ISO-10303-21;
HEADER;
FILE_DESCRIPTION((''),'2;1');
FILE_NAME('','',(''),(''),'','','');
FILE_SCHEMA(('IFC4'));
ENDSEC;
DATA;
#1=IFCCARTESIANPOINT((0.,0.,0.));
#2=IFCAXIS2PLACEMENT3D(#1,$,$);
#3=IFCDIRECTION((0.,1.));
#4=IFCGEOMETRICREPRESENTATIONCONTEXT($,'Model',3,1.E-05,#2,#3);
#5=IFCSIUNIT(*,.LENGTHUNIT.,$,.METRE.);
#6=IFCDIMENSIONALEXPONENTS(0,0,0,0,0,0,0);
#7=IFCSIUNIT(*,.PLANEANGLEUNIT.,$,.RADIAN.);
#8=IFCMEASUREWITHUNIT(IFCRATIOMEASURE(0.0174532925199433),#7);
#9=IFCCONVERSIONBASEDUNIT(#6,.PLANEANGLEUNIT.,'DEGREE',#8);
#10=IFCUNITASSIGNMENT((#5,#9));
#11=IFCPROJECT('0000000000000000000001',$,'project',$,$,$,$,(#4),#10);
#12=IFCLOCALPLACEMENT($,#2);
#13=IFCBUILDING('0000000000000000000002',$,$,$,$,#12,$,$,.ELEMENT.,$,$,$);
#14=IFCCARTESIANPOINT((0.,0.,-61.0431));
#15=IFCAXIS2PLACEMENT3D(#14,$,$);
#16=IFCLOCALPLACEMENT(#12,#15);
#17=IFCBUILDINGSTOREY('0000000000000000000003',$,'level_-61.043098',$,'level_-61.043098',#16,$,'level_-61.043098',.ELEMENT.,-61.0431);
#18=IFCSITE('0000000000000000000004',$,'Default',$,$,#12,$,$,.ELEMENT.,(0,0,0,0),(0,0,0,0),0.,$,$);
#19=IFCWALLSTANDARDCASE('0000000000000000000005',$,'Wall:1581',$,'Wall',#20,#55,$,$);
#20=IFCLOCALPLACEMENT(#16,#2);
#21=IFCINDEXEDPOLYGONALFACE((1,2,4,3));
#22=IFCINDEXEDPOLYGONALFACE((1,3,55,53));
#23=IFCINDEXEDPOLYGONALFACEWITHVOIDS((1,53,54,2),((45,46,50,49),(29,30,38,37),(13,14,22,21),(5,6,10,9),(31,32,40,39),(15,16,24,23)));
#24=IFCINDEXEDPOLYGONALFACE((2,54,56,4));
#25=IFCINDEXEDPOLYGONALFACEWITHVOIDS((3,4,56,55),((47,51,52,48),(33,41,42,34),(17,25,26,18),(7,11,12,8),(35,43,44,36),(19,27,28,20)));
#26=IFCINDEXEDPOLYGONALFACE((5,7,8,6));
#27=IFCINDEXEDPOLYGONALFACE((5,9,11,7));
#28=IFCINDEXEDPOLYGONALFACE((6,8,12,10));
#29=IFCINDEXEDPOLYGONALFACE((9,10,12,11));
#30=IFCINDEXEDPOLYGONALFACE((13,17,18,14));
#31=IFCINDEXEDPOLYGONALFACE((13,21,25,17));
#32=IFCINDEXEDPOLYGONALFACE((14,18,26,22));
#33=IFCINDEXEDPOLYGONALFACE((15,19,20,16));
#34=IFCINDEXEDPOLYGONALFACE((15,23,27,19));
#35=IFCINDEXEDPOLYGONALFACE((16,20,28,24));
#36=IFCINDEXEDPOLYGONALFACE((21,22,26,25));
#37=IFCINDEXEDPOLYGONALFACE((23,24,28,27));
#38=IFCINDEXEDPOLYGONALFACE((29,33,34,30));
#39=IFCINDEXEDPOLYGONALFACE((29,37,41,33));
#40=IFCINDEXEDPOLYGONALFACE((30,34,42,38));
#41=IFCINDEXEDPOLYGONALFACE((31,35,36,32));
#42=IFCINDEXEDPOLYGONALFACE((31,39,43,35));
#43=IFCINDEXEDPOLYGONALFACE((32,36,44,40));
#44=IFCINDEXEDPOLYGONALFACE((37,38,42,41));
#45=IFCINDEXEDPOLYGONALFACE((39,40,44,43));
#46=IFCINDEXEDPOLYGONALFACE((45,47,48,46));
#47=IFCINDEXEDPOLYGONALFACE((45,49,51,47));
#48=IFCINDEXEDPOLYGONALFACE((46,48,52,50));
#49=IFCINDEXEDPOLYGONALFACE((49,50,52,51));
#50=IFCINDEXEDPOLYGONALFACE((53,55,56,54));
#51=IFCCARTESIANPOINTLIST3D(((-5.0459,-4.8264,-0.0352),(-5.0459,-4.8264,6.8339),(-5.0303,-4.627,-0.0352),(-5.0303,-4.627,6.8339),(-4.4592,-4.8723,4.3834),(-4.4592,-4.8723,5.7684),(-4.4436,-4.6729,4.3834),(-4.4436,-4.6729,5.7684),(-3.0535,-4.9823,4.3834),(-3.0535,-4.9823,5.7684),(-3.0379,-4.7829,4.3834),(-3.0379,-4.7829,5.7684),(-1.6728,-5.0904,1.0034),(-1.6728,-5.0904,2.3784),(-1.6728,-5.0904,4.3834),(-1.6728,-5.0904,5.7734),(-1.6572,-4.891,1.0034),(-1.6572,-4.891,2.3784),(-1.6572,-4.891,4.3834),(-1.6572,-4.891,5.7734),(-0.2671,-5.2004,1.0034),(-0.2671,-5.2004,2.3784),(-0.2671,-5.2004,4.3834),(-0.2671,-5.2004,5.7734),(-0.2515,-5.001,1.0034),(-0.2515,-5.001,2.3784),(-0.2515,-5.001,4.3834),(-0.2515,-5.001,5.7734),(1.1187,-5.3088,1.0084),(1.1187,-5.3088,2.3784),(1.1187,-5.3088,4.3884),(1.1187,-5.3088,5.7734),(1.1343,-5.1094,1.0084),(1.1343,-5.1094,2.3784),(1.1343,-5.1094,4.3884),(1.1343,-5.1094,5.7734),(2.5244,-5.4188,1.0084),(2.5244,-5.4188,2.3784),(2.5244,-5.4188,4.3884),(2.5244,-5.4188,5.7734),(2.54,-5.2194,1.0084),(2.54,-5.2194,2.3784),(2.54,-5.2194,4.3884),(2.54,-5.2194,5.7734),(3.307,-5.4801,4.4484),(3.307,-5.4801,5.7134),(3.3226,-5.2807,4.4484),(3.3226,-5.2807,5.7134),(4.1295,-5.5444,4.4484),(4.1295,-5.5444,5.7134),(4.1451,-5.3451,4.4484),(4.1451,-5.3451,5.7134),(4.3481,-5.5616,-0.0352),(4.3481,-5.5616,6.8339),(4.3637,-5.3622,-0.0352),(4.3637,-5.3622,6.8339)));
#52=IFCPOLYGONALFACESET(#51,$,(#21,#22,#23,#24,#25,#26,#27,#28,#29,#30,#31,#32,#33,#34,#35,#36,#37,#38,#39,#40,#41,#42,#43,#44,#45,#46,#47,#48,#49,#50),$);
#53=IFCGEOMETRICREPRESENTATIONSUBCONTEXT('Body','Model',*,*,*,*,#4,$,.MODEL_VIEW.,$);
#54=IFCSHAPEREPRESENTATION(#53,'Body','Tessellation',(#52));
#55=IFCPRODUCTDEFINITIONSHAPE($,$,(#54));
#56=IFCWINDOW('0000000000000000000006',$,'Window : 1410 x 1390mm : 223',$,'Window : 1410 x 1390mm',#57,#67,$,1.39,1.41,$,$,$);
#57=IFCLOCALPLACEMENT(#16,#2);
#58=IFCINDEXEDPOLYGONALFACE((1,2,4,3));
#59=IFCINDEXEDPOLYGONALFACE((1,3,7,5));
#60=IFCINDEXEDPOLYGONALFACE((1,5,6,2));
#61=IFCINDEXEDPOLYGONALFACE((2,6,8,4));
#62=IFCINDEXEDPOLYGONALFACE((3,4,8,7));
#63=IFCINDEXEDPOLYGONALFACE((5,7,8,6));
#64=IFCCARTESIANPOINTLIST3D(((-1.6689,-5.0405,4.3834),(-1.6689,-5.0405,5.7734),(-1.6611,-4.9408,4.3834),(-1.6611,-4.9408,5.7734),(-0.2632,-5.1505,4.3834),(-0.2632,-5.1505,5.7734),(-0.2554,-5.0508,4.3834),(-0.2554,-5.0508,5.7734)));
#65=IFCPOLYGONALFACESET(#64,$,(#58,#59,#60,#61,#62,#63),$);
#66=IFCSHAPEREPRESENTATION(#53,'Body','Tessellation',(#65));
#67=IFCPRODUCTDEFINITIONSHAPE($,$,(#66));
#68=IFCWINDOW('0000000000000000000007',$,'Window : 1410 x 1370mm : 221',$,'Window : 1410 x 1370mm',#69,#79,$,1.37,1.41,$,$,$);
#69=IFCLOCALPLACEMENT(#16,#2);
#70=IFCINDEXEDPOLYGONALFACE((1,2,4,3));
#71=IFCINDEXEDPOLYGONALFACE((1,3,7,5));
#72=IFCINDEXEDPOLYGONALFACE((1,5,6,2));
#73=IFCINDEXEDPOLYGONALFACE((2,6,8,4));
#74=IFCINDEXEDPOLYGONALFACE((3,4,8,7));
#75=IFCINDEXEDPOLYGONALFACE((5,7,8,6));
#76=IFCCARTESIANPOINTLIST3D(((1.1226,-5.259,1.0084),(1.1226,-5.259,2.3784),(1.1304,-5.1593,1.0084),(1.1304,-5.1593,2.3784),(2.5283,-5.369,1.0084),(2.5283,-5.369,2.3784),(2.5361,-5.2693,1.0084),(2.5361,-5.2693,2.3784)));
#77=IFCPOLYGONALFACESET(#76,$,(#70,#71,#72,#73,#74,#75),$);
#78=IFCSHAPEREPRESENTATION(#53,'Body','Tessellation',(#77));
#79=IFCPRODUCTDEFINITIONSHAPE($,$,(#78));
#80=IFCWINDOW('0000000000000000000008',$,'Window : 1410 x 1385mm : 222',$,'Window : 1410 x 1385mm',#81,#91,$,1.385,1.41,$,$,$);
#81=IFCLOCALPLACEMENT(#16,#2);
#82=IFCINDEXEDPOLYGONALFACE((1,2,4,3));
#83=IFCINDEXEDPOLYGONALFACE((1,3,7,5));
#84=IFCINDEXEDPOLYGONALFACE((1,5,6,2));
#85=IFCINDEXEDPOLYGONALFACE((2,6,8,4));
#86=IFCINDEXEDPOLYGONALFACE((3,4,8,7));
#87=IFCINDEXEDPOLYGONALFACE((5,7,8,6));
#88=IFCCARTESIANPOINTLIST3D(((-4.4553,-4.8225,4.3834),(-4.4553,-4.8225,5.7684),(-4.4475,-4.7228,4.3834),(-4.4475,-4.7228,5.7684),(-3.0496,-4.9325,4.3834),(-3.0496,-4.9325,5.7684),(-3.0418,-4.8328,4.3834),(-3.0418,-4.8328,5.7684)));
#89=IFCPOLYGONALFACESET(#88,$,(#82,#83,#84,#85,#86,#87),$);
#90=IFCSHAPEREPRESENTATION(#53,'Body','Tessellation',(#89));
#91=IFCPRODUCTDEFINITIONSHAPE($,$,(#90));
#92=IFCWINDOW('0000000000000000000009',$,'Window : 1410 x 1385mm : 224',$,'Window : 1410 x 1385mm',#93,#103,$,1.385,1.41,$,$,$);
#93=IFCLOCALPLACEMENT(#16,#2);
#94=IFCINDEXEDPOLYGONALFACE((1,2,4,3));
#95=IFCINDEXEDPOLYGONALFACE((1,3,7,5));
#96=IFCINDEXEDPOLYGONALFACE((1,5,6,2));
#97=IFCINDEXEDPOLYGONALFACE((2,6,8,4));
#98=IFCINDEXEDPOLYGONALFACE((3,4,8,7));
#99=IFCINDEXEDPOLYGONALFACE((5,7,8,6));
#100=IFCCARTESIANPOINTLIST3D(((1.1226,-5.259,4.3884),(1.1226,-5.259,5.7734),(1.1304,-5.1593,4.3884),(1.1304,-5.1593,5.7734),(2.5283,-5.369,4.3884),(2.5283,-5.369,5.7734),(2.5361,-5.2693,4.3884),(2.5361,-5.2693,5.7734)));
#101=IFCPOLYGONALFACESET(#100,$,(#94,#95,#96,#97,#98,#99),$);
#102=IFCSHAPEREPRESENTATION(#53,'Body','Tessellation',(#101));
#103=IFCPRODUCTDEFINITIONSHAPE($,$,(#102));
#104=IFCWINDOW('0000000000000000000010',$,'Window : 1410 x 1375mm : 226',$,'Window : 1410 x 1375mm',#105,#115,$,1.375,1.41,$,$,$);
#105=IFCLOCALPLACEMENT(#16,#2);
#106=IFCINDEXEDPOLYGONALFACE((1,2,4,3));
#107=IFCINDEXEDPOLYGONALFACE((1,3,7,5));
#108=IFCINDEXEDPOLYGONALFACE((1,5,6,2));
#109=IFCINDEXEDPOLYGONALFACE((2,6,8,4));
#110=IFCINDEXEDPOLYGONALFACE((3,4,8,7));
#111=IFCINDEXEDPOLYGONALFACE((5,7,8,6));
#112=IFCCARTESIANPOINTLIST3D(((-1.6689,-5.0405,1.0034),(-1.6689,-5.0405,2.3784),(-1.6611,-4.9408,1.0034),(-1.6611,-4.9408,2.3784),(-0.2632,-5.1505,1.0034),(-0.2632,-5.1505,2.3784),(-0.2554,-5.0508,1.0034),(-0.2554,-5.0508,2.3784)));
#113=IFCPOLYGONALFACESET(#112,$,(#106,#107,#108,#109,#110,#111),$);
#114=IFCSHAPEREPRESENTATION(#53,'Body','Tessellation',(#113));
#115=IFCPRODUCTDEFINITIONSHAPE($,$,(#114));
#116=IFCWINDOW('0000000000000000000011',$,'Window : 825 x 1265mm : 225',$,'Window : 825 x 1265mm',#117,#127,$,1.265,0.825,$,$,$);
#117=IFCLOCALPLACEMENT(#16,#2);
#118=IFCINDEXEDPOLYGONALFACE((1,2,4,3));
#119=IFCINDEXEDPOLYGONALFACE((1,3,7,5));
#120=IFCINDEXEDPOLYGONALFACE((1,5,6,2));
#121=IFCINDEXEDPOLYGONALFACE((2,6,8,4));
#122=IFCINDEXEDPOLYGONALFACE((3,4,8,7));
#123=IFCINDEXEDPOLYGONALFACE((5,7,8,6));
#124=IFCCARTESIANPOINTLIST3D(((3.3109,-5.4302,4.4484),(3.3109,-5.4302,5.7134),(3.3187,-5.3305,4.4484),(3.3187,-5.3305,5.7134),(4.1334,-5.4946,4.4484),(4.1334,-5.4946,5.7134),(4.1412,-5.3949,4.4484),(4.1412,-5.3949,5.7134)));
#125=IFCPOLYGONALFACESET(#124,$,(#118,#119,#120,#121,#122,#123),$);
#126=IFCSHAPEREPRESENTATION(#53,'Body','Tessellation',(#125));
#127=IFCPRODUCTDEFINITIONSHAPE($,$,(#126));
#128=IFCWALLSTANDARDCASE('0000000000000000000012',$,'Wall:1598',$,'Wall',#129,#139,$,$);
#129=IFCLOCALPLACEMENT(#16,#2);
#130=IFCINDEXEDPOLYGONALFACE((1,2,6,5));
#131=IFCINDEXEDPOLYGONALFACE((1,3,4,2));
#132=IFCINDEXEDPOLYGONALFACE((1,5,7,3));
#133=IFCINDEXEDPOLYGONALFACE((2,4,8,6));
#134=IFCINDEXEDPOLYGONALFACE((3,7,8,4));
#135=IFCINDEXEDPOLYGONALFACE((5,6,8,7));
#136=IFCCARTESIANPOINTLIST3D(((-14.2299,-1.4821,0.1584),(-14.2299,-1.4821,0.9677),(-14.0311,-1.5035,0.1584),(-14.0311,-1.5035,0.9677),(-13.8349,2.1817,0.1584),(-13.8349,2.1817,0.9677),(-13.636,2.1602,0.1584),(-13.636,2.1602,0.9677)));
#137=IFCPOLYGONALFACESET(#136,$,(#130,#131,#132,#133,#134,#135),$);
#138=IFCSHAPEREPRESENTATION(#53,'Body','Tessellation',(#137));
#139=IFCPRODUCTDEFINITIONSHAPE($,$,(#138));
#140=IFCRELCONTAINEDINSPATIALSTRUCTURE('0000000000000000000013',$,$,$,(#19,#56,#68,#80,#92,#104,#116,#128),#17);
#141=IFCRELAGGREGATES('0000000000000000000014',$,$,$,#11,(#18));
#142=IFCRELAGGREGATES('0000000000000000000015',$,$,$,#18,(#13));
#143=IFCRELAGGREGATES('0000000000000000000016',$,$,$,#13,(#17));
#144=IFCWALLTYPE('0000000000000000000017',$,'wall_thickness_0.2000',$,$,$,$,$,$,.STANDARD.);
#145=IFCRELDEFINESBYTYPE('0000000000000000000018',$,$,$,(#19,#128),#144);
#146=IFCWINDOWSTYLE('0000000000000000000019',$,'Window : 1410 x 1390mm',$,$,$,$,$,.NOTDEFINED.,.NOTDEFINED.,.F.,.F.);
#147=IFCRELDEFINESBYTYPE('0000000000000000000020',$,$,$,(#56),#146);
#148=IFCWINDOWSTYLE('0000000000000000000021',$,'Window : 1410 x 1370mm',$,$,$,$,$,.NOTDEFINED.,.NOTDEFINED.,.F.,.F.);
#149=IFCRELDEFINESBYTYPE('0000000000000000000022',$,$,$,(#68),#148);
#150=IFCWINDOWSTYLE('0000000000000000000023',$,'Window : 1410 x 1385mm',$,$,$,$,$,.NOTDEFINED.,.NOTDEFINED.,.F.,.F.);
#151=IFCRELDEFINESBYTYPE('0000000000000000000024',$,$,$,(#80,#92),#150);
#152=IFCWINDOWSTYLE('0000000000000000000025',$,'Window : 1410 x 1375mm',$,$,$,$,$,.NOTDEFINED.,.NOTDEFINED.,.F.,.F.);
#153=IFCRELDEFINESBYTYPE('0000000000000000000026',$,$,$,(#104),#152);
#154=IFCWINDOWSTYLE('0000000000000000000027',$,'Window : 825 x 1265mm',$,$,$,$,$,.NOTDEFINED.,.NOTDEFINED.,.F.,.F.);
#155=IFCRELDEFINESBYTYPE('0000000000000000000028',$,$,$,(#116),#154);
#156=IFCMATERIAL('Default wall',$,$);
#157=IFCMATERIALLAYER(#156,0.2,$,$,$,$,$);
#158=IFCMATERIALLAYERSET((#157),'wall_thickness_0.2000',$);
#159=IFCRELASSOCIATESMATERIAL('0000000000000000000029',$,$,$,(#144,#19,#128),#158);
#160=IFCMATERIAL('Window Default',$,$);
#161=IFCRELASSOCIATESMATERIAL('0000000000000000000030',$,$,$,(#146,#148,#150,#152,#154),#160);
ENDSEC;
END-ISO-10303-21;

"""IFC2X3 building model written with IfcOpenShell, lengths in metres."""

from ifc_helpers import new_model, entity, si_unit, converted_unit, direction, frame, frame_2d, origin, origin_2d_with_axis, place, context, subcontext, project, spatial, polyline, rectangle, outline, extrude, source, transform, mapped, material, layer, layer_set, layer_usage, type_object, type_shapes, element, fill, save


model = new_model("IFC2X3")

# Units and contexts
model_context = context("Model", 3, precision=1e-05, world=origin(), true_north=direction((0.0, 1.0)))
body_context = subcontext(model_context, "Body", "Model", "MODEL_VIEW")
ifc_project = project(units=[si_unit("LENGTHUNIT", "METRE"), converted_unit("PLANEANGLEUNIT", "DEGREE", entity("IfcRatioMeasure", 0.0174532925199433), si_unit("PLANEANGLEUNIT", "RADIAN"), dimensions=[0, 0, 0, 0, 0, 0, 0])], contexts=[model_context])

# Site, building, storey
placement_1 = place(None, origin())
site = spatial("IfcSite", under=ifc_project, at=placement_1, Name="Default", CompositionType="ELEMENT", RefLatitude=(0, 0, 0, 0), RefLongitude=(0, 0, 0, 0), RefElevation=0.0)
building = spatial("IfcBuilding", under=site, at=placement_1, CompositionType="ELEMENT")
storey_placement = place(placement_1, frame((0.0, 0.0, -61.0431)))
storey = spatial("IfcBuildingStorey", under=building, at=storey_placement, Name="level_-61.043098", ObjectType="level_-61.043098", LongName="level_-61.043098", CompositionType="ELEMENT", Elevation=-61.0431)

# Shared definitions
ifc_material_1 = material(Name="Default wall")
ifc_layer = layer(ifc_material_1, 0.2)
ifc_layer_set = layer_set([ifc_layer], Name="wall_thickness_0.2000")
ifc_layer_usage = layer_usage(ifc_layer_set, "AXIS2", "POSITIVE", -0.1)
wall_type = type_object("IfcWallType", Name="wall_thickness_0.2000", PredefinedType="STANDARD", material=ifc_layer_set)

# Wall, openings, windows
placement_2 = place(placement_1, frame((0.0, 0.0, -61.0783)))
wall_1_placement = place(placement_2, frame((-5.0381, -4.7267, 0.0), z_axis=(0.0, 0.0, 1.0), x_axis=(0.996952, -0.078016, 0.0)))
wall_1 = element("IfcWallStandardCase", 1, at=wall_1_placement, inside=storey, type_object=wall_type, material=ifc_layer_usage, Name="Wall:1581", ObjectType="Wall", context=body_context, shape_type="SweptSolid", body=[
    extrude(outline(polyline([(9.4227, -0.1), (9.4227, 0.1), (0.0, 0.1), (0.0, -0.1), (9.4227, -0.1)])), origin(), (0.0, 0.0, 1.0), 6.8691),
])
opening_1_placement = place(wall_1_placement, frame((6.1834, -0.1, 1.0436)))
opening_1 = element("IfcOpeningElement", 2, at=opening_1_placement, cuts=wall_1, ObjectType="Opening", context=body_context, shape_type="SweptSolid", body=[
    extrude(rectangle(XDim=1.41, YDim=1.37, at=frame_2d((0.685, 0.705), x_axis=(0.0, 1.0))), frame((0.0, 0.0, 0.0), z_axis=(0.0, 1.0, 0.0), x_axis=(0.0, 0.0, 1.0)), (0.0, 0.0, 1.0), 0.2),
])
opening_2_placement = place(wall_1_placement, frame((0.5884, -0.1, 4.4186)))
opening_2 = element("IfcOpeningElement", 3, at=opening_2_placement, cuts=wall_1, ObjectType="Opening", context=body_context, shape_type="SweptSolid", body=[
    extrude(rectangle(XDim=1.41, YDim=1.385, at=frame_2d((0.6925, 0.705), x_axis=(0.0, 1.0))), frame((0.0, 0.0, 0.0), z_axis=(0.0, 1.0, 0.0), x_axis=(0.0, 0.0, 1.0)), (0.0, 0.0, 1.0), 0.2),
])
opening_3_placement = place(wall_1_placement, frame((3.3834, -0.1, 4.4186)))
opening_3 = element("IfcOpeningElement", 4, at=opening_3_placement, cuts=wall_1, ObjectType="Opening", context=body_context, shape_type="SweptSolid", body=[
    extrude(rectangle(XDim=1.41, YDim=1.39, at=frame_2d((0.695, 0.705), x_axis=(0.0, 1.0))), frame((0.0, 0.0, 0.0), z_axis=(0.0, 1.0, 0.0), x_axis=(0.0, 0.0, 1.0)), (0.0, 0.0, 1.0), 0.2),
])
opening_4_placement = place(wall_1_placement, frame((6.1834, -0.1, 4.4236)))
opening_4 = element("IfcOpeningElement", 5, at=opening_4_placement, cuts=wall_1, ObjectType="Opening", context=body_context, shape_type="SweptSolid", body=[
    extrude(rectangle(XDim=1.41, YDim=1.385, at=frame_2d((0.6925, 0.705), x_axis=(0.0, 1.0))), frame((0.0, 0.0, 0.0), z_axis=(0.0, 1.0, 0.0), x_axis=(0.0, 0.0, 1.0)), (0.0, 0.0, 1.0), 0.2),
])
opening_5_placement = place(wall_1_placement, frame((8.3784, -0.1, 4.4836)))
opening_5 = element("IfcOpeningElement", 6, at=opening_5_placement, cuts=wall_1, ObjectType="Opening", context=body_context, shape_type="SweptSolid", body=[
    extrude(rectangle(XDim=0.825, YDim=1.265, at=frame_2d((0.6325, 0.4125), x_axis=(0.0, 1.0))), frame((0.0, 0.0, 0.0), z_axis=(0.0, 1.0, 0.0), x_axis=(0.0, 0.0, 1.0)), (0.0, 0.0, 1.0), 0.2),
])
opening_6_placement = place(wall_1_placement, frame((3.3834, -0.1, 1.0386)))
opening_6 = element("IfcOpeningElement", 7, at=opening_6_placement, cuts=wall_1, ObjectType="Opening", context=body_context, shape_type="SweptSolid", body=[
    extrude(rectangle(XDim=1.41, YDim=1.375, at=frame_2d((0.6875, 0.705), x_axis=(0.0, 1.0))), frame((0.0, 0.0, 0.0), z_axis=(0.0, 1.0, 0.0), x_axis=(0.0, 0.0, 1.0)), (0.0, 0.0, 1.0), 0.2),
])
ifc_material_2 = material(Name="Window Default")
window_style_1 = type_object("IfcWindowStyle", Name="Window : 1410 x 1390mm", ConstructionType="NOTDEFINED", OperationType="NOTDEFINED", ParameterTakesPrecedence=False, Sizeable=False, material=ifc_material_2)
shared_shape_1 = source(origin(), body_context, "Body", "SweptSolid", [
    extrude(rectangle(XDim=0.1, YDim=1.41, at=origin_2d_with_axis()), frame((0.705, 0.1, 0.0), z_axis=(0.0, 0.0, 1.0), x_axis=(0.0, 1.0, 0.0)), (0.0, 0.0, 1.0), 1.39),
])
type_shapes(window_style_1, [shared_shape_1])
window_1_placement = place(opening_3_placement, origin())
window_1 = element("IfcWindow", 8, at=window_1_placement, inside=storey, type_object=window_style_1, Name="Window : 1410 x 1390mm : 223", ObjectType="Window : 1410 x 1390mm", OverallHeight=1.39, OverallWidth=1.41, context=body_context, shape_type="MappedRepresentation", body=[
    mapped(shared_shape_1, transform((0.0, 0.0, 0.0), scale=1.0)),
])
fill(opening_3, window_1)
window_style_2 = type_object("IfcWindowStyle", Name="Window : 1410 x 1370mm", ConstructionType="NOTDEFINED", OperationType="NOTDEFINED", ParameterTakesPrecedence=False, Sizeable=False, material=ifc_material_2)
shared_shape_2 = source(origin(), body_context, "Body", "SweptSolid", [
    extrude(rectangle(XDim=0.1, YDim=1.41, at=origin_2d_with_axis()), frame((0.705, 0.1, 0.0), z_axis=(0.0, 0.0, 1.0), x_axis=(0.0, 1.0, 0.0)), (0.0, 0.0, 1.0), 1.37),
])
type_shapes(window_style_2, [shared_shape_2])
window_2_placement = place(opening_1_placement, origin())
window_2 = element("IfcWindow", 9, at=window_2_placement, inside=storey, type_object=window_style_2, Name="Window : 1410 x 1370mm : 221", ObjectType="Window : 1410 x 1370mm", OverallHeight=1.37, OverallWidth=1.41, context=body_context, shape_type="MappedRepresentation", body=[
    mapped(shared_shape_2, transform((0.0, 0.0, 0.0), scale=1.0)),
])
fill(opening_1, window_2)
window_style_3 = type_object("IfcWindowStyle", Name="Window : 1410 x 1385mm", ConstructionType="NOTDEFINED", OperationType="NOTDEFINED", ParameterTakesPrecedence=False, Sizeable=False, material=ifc_material_2)
shared_shape_3 = source(origin(), body_context, "Body", "SweptSolid", [
    extrude(rectangle(XDim=0.1, YDim=1.41, at=origin_2d_with_axis()), frame((0.705, 0.1, 0.0), z_axis=(0.0, 0.0, 1.0), x_axis=(0.0, 1.0, 0.0)), (0.0, 0.0, 1.0), 1.385),
])
type_shapes(window_style_3, [shared_shape_3])
window_3_placement = place(opening_2_placement, origin())
window_3 = element("IfcWindow", 10, at=window_3_placement, inside=storey, type_object=window_style_3, Name="Window : 1410 x 1385mm : 222", ObjectType="Window : 1410 x 1385mm", OverallHeight=1.385, OverallWidth=1.41, context=body_context, shape_type="MappedRepresentation", body=[
    mapped(shared_shape_3, transform((0.0, 0.0, 0.0), scale=1.0)),
])
fill(opening_2, window_3)
window_4_placement = place(opening_4_placement, origin())
window_4 = element("IfcWindow", 11, at=window_4_placement, inside=storey, type_object=window_style_3, Name="Window : 1410 x 1385mm : 224", ObjectType="Window : 1410 x 1385mm", OverallHeight=1.385, OverallWidth=1.41, context=body_context, shape_type="MappedRepresentation", body=[
    mapped(shared_shape_3, transform((0.0, 0.0, 0.0), scale=1.0)),
])
fill(opening_4, window_4)
window_style_4 = type_object("IfcWindowStyle", Name="Window : 1410 x 1375mm", ConstructionType="NOTDEFINED", OperationType="NOTDEFINED", ParameterTakesPrecedence=False, Sizeable=False, material=ifc_material_2)
shared_shape_4 = source(origin(), body_context, "Body", "SweptSolid", [
    extrude(rectangle(XDim=0.1, YDim=1.41, at=origin_2d_with_axis()), frame((0.705, 0.1, 0.0), z_axis=(0.0, 0.0, 1.0), x_axis=(0.0, 1.0, 0.0)), (0.0, 0.0, 1.0), 1.375),
])
type_shapes(window_style_4, [shared_shape_4])
window_5_placement = place(opening_6_placement, origin())
window_5 = element("IfcWindow", 12, at=window_5_placement, inside=storey, type_object=window_style_4, Name="Window : 1410 x 1375mm : 226", ObjectType="Window : 1410 x 1375mm", OverallHeight=1.375, OverallWidth=1.41, context=body_context, shape_type="MappedRepresentation", body=[
    mapped(shared_shape_4, transform((0.0, 0.0, 0.0), scale=1.0)),
])
fill(opening_6, window_5)
window_style_5 = type_object("IfcWindowStyle", Name="Window : 825 x 1265mm", ConstructionType="NOTDEFINED", OperationType="NOTDEFINED", ParameterTakesPrecedence=False, Sizeable=False, material=ifc_material_2)
shared_shape_5 = source(origin(), body_context, "Body", "SweptSolid", [
    extrude(rectangle(XDim=0.1, YDim=0.825, at=origin_2d_with_axis()), frame((0.4125, 0.1, 0.0), z_axis=(0.0, 0.0, 1.0), x_axis=(0.0, 1.0, 0.0)), (0.0, 0.0, 1.0), 1.265),
])
type_shapes(window_style_5, [shared_shape_5])
window_6_placement = place(opening_5_placement, origin())
window_6 = element("IfcWindow", 13, at=window_6_placement, inside=storey, type_object=window_style_5, Name="Window : 825 x 1265mm : 225", ObjectType="Window : 825 x 1265mm", OverallHeight=1.265, OverallWidth=0.825, context=body_context, shape_type="MappedRepresentation", body=[
    mapped(shared_shape_5, transform((0.0, 0.0, 0.0), scale=1.0)),
])
fill(opening_5, window_6)

# Wall
placement_3 = place(placement_1, frame((0.0, 0.0, -60.8847)))
wall_2_placement = place(placement_3, frame((-14.1305, -1.4928, 0.0), z_axis=(0.0, 0.0, 1.0), x_axis=(0.107206, 0.994237, 0.0)))
element("IfcWallStandardCase", 14, at=wall_2_placement, inside=storey, type_object=wall_type, material=ifc_layer_usage, Name="Wall:1598", ObjectType="Wall", context=body_context, shape_type="SweptSolid", body=[
    extrude(outline(polyline([(3.685, -0.1), (3.685, 0.1), (0.0, 0.1), (0.0, -0.1), (3.685, -0.1)])), origin(), (0.0, 0.0, 1.0), 0.8093),
])

save(model, "model.ifc")
